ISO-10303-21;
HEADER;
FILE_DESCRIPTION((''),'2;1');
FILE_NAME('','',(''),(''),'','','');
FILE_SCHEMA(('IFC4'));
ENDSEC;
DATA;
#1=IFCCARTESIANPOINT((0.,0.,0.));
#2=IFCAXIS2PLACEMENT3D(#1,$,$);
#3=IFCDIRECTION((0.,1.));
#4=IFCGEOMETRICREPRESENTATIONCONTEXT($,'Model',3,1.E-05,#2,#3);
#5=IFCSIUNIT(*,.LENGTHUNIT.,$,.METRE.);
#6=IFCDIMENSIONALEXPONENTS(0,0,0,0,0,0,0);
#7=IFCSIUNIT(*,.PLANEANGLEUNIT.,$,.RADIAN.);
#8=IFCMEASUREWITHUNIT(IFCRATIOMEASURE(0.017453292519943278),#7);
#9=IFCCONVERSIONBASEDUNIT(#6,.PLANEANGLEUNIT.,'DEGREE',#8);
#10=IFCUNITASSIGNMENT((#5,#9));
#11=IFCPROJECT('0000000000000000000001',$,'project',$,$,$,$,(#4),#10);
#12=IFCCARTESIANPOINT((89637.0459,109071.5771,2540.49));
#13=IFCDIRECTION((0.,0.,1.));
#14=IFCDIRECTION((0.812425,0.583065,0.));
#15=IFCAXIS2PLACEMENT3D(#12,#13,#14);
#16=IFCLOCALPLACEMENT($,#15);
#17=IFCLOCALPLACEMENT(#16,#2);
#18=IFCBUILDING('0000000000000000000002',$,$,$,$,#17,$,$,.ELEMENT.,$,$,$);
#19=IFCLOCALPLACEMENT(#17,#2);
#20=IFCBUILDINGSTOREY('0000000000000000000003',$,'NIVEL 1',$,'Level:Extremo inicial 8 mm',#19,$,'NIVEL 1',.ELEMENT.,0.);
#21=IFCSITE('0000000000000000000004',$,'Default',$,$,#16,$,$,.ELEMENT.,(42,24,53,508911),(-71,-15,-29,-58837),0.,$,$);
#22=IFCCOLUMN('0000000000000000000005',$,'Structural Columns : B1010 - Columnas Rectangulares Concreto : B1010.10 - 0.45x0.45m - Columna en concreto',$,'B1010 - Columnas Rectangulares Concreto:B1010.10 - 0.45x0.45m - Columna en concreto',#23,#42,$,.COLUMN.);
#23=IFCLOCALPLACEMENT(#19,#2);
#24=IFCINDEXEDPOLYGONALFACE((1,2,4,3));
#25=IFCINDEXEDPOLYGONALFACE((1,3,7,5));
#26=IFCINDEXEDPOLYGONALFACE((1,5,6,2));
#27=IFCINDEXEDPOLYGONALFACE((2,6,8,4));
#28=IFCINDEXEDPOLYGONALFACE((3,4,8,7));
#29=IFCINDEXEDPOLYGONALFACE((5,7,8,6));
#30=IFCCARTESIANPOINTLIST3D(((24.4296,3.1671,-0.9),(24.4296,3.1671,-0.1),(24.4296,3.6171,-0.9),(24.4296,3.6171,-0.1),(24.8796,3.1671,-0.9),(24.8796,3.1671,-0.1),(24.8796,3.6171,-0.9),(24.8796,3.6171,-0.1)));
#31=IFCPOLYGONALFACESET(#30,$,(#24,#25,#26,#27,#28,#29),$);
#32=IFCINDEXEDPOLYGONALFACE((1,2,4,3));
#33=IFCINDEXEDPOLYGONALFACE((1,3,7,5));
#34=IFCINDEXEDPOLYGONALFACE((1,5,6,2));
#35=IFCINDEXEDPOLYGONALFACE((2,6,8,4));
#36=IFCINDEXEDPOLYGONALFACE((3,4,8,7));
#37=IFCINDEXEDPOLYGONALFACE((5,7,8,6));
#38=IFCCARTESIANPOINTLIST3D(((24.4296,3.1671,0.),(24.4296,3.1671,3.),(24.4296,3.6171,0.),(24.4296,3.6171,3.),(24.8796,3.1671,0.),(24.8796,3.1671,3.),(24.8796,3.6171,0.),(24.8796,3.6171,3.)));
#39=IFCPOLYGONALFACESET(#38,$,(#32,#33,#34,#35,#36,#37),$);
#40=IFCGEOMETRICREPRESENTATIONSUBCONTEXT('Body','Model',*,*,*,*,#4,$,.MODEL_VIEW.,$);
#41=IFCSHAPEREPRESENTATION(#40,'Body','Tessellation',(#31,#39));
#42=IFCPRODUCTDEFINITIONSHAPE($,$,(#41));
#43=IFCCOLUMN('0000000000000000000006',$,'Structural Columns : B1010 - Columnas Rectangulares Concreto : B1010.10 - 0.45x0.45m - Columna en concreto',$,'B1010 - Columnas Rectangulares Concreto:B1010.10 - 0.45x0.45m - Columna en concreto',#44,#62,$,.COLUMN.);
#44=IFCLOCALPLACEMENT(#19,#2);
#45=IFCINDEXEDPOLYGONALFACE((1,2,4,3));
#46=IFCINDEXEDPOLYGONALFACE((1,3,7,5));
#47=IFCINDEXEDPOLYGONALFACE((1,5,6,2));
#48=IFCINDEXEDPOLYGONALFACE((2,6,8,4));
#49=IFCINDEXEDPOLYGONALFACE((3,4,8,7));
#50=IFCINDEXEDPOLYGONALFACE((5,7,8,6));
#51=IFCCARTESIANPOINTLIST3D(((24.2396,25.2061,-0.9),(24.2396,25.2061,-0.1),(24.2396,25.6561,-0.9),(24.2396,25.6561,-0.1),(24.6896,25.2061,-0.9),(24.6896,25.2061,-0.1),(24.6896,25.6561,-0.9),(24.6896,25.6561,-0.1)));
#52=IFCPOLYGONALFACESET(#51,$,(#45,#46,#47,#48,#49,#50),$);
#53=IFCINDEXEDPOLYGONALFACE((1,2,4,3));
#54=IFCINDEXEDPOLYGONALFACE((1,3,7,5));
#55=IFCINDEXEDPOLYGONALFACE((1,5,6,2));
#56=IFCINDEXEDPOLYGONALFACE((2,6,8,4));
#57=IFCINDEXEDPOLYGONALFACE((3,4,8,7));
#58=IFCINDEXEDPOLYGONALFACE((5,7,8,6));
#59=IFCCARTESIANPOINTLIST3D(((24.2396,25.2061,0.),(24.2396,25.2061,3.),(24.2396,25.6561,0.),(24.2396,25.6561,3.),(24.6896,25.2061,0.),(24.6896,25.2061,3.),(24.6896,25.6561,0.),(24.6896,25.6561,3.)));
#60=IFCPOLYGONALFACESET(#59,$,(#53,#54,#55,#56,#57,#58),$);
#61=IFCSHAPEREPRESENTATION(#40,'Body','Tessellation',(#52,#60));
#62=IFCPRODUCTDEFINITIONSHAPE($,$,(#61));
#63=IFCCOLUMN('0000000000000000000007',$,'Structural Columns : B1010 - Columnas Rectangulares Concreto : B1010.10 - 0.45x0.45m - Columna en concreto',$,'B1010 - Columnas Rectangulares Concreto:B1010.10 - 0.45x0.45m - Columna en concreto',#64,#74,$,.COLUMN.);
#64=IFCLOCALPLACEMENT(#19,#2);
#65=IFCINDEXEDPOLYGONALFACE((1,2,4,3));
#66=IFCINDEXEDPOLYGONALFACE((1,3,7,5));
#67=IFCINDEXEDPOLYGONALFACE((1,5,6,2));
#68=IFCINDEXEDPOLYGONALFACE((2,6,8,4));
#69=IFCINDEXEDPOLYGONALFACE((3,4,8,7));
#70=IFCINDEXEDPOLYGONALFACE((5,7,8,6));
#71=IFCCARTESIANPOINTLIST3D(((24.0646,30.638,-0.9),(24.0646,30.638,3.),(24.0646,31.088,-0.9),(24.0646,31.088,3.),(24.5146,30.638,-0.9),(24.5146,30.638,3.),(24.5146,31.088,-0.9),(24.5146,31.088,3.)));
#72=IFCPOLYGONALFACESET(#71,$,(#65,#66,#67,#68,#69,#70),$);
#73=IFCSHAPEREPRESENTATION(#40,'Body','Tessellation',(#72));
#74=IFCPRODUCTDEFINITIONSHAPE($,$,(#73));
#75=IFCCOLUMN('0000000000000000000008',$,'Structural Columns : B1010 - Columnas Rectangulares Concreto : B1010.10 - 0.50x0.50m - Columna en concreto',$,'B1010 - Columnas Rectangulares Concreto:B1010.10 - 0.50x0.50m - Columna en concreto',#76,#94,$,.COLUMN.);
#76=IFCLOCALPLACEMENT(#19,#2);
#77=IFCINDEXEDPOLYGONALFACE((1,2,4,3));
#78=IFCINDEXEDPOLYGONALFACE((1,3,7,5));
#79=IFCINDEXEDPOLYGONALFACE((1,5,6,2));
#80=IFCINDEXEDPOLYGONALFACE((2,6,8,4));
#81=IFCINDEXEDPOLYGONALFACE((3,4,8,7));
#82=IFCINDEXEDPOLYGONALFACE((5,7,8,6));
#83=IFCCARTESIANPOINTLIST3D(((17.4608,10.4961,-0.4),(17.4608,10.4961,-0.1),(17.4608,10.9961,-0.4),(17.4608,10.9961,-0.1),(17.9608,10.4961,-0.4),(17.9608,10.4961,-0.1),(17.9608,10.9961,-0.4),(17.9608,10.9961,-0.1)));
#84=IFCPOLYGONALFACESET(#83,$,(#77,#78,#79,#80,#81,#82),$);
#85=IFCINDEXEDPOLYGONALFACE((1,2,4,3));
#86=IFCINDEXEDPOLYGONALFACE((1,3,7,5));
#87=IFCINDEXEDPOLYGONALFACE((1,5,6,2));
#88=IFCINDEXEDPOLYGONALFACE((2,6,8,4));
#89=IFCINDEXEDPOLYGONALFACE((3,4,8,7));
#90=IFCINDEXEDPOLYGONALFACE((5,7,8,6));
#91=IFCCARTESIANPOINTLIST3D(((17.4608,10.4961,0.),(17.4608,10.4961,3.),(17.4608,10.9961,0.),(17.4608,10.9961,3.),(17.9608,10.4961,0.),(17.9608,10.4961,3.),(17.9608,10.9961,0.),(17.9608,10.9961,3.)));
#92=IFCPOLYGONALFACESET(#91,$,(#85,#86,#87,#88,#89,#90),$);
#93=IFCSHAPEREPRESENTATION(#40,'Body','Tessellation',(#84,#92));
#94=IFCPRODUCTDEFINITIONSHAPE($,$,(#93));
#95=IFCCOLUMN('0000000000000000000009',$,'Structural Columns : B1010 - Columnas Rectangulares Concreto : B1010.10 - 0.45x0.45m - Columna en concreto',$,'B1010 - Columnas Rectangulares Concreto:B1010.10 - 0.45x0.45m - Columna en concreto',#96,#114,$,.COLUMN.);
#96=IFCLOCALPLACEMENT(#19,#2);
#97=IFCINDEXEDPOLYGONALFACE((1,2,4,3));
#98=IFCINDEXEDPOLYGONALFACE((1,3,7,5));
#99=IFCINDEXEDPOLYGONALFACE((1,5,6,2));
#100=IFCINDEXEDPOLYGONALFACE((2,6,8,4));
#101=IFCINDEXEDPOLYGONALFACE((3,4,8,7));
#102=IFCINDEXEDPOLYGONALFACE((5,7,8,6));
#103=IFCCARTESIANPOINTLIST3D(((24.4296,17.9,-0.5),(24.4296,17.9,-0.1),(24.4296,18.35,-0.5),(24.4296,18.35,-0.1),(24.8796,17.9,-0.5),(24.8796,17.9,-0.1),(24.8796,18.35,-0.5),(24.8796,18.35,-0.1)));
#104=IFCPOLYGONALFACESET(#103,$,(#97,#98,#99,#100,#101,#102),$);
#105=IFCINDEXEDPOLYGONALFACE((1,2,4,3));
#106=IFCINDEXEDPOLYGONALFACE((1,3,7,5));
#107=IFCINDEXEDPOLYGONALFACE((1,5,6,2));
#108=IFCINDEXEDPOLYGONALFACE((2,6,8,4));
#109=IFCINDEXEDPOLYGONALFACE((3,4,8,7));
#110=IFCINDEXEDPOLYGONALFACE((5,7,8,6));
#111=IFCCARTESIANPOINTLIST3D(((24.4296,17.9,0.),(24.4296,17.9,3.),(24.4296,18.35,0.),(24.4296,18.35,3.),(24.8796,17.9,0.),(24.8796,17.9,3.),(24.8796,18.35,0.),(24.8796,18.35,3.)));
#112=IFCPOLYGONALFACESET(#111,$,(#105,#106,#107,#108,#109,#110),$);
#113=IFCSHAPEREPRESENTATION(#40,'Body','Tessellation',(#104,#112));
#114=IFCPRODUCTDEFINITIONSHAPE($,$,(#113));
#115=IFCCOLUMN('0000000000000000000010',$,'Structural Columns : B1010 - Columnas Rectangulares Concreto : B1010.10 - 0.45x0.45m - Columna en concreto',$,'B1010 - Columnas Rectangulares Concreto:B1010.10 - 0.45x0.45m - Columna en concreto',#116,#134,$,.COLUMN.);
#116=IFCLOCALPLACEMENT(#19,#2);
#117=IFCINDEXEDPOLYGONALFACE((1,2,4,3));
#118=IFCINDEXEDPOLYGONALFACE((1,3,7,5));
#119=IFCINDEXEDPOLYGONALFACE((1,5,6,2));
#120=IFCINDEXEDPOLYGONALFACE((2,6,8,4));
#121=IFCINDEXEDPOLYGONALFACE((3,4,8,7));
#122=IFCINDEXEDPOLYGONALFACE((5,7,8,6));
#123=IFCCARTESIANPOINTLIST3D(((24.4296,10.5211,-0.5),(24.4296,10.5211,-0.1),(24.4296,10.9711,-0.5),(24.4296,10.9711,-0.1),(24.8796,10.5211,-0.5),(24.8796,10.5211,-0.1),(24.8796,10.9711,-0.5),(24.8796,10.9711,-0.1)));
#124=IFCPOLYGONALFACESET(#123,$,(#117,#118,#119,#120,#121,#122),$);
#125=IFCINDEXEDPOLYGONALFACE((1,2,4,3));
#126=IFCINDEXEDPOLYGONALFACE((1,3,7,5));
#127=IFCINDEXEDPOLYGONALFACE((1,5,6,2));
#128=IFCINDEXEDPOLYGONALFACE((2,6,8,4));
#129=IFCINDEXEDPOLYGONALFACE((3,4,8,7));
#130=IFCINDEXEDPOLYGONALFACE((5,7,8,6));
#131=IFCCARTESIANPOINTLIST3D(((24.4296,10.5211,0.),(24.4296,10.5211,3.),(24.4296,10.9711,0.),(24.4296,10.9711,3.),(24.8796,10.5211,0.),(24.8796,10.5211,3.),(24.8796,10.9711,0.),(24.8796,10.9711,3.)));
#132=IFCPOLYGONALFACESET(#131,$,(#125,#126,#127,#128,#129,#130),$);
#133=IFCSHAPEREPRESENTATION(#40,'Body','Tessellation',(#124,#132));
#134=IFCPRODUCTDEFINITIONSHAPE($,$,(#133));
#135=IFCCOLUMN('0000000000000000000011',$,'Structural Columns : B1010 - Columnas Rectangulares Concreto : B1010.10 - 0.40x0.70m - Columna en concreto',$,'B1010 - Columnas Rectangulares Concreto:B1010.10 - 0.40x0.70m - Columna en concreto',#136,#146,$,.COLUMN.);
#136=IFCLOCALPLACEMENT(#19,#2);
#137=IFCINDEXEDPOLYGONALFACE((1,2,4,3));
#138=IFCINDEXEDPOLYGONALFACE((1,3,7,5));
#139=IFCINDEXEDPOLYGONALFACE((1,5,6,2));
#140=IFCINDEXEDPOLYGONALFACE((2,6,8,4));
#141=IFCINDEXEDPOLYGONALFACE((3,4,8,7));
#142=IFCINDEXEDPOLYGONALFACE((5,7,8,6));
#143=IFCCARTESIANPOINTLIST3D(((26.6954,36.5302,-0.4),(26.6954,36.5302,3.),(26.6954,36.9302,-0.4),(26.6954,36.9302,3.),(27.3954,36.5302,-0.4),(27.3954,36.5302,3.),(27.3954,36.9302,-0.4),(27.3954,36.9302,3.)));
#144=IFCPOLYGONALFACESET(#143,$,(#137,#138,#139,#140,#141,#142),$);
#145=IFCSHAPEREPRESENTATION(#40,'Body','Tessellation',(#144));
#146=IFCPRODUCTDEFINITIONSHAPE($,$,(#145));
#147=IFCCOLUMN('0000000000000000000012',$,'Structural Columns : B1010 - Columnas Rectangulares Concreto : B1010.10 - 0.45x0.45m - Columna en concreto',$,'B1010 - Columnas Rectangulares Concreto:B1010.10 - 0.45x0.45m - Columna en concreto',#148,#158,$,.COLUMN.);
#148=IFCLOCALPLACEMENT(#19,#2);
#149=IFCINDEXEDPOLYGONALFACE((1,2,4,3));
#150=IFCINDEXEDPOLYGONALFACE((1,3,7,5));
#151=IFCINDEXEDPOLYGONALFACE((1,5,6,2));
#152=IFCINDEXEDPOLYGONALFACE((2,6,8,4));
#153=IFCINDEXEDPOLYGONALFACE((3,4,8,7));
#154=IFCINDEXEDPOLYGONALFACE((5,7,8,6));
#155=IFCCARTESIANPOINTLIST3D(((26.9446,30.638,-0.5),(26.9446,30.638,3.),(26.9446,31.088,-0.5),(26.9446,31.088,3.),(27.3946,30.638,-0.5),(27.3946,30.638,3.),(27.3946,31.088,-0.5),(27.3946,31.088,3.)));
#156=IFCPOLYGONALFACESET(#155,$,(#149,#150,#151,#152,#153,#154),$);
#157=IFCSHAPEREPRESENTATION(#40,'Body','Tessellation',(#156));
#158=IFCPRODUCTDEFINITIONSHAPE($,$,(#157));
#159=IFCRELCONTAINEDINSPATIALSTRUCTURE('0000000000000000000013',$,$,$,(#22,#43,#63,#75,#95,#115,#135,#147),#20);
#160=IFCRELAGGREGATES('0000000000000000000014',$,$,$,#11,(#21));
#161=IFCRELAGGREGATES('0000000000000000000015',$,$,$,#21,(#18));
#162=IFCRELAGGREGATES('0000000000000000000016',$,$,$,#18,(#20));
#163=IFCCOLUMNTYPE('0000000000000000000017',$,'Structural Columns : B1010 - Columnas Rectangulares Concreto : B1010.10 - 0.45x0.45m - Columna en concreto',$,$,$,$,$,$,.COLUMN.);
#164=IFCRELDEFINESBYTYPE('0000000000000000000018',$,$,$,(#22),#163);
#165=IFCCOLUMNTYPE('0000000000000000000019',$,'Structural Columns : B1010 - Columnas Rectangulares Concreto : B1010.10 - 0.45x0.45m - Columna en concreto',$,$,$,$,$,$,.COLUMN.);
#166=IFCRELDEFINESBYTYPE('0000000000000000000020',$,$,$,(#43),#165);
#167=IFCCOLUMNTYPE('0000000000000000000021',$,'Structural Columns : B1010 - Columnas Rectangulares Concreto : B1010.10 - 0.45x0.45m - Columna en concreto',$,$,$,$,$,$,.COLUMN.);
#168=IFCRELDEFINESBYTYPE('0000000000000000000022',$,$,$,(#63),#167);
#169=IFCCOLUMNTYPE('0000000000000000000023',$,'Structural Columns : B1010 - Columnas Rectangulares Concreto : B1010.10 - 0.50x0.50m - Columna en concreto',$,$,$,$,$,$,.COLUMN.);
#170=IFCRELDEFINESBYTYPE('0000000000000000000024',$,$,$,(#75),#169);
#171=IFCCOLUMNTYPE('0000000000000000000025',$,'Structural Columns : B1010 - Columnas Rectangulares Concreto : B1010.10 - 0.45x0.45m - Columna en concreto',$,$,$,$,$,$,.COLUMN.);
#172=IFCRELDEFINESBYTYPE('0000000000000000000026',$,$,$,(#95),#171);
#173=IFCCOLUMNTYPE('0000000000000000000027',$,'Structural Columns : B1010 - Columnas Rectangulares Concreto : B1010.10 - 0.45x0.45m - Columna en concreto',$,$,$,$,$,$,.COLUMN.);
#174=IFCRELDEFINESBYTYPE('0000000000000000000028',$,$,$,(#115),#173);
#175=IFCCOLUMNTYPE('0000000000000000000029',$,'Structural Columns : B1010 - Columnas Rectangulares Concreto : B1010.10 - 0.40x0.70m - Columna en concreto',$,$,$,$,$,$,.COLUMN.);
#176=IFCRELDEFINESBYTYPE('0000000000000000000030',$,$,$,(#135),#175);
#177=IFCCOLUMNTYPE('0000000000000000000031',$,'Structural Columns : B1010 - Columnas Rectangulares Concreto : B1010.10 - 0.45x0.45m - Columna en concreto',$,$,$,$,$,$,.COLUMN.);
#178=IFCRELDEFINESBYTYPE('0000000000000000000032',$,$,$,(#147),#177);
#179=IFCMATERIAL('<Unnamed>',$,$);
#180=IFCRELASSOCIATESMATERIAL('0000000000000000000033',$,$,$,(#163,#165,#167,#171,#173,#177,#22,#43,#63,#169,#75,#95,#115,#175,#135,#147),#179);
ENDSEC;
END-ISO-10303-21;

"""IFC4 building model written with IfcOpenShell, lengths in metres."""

from ifc_helpers import new_model, entity, si_unit, converted_unit, direction, frame, frame_2d, origin, origin_2d_with_axis, place, context, subcontext, project, spatial, polyline, segment, composite_curve, rectangle, outline, extrude, source, transform, mapped, material, material_profile, profile_set, profile_usage, type_object, type_shapes, element, save


model = new_model("IFC4")

# Units and contexts
model_context = context("Model", 3, precision=1e-05, world=origin(), true_north=direction((0.0, 1.0)))
body_context = subcontext(model_context, "Body", "Model", "MODEL_VIEW")
ifc_project = project(units=[si_unit("LENGTHUNIT", "METRE"), converted_unit("PLANEANGLEUNIT", "DEGREE", entity("IfcRatioMeasure", 0.017453292519943278), si_unit("PLANEANGLEUNIT", "RADIAN"), dimensions=[0, 0, 0, 0, 0, 0, 0])], contexts=[model_context])

# Site, building, storey
site_placement = place(None, frame((89637.0459, 109071.5771, 2540.49), z_axis=(0.0, 0.0, 1.0), x_axis=(0.812425, 0.583065, 0.0)))
site = spatial("IfcSite", under=ifc_project, at=site_placement, Name="Default", CompositionType="ELEMENT", RefLatitude=(42, 24, 53, 508911), RefLongitude=(-71, -15, -29, -58837), RefElevation=0.0)
building_placement = place(site_placement, origin())
building = spatial("IfcBuilding", under=site, at=building_placement, CompositionType="ELEMENT")
storey_placement = place(building_placement, origin())
storey = spatial("IfcBuildingStorey", under=building, at=storey_placement, Name="NIVEL 1", ObjectType="Level:Extremo inicial 8 mm", LongName="NIVEL 1", CompositionType="ELEMENT", Elevation=0.0)

# Columns
ifc_material = material(Name="<Unnamed>")
ifc_material_profile_1 = material_profile(ifc_material, outline(composite_curve([segment(polyline([(0.35, 0.2, 0.0), (0.35, -0.2, 0.0)]), True, "CONTINUOUS"), segment(polyline([(0.35, -0.2, 0.0), (-0.35, -0.2, 0.0)]), True, "CONTINUOUS"), segment(polyline([(-0.35, -0.2, 0.0), (-0.35, 0.2, 0.0)]), True, "CONTINUOUS"), segment(polyline([(-0.35, 0.2, 0.0), (0.35, 0.2, 0.0)]), True, "CONTINUOUS")], self_intersect=False), kind="CURVE"), Name="B1010.10 - 0.40x0.70m - Columna en concreto")
ifc_material_profile_2 = material_profile(ifc_material, outline(composite_curve([segment(polyline([(0.35, 0.2, 3.0), (-0.35, 0.2, 3.0)]), True, "CONTINUOUS"), segment(polyline([(-0.35, 0.2, 3.0), (-0.35, -0.2, 3.0)]), True, "CONTINUOUS"), segment(polyline([(-0.35, -0.2, 3.0), (0.35, -0.2, 3.0)]), True, "CONTINUOUS"), segment(polyline([(0.35, -0.2, 3.0), (0.35, 0.2, 3.0)]), True, "CONTINUOUS")], self_intersect=False), kind="CURVE"), Name="B1010.10 - 0.40x0.70m - Columna en concreto")
ifc_profile_set_1 = profile_set([ifc_material_profile_1, ifc_material_profile_2], Name="B1010.10 - 0.40x0.70m - Columna en concreto")
ifc_material_profile_3 = material_profile(ifc_material, outline(composite_curve([segment(polyline([(0.225, 0.225, 0.0), (0.225, -0.225, 0.0)]), True, "CONTINUOUS"), segment(polyline([(0.225, -0.225, 0.0), (-0.225, -0.225, 0.0)]), True, "CONTINUOUS"), segment(polyline([(-0.225, -0.225, 0.0), (-0.225, 0.225, 0.0)]), True, "CONTINUOUS"), segment(polyline([(-0.225, 0.225, 0.0), (0.225, 0.225, 0.0)]), True, "CONTINUOUS")], self_intersect=False), kind="CURVE"), Name="B1010.10 - 0.45x0.45m - Columna en concreto")
ifc_material_profile_4 = material_profile(ifc_material, outline(composite_curve([segment(polyline([(0.225, 0.225, 3.0), (-0.225, 0.225, 3.0)]), True, "CONTINUOUS"), segment(polyline([(-0.225, 0.225, 3.0), (-0.225, -0.225, 3.0)]), True, "CONTINUOUS"), segment(polyline([(-0.225, -0.225, 3.0), (0.225, -0.225, 3.0)]), True, "CONTINUOUS"), segment(polyline([(0.225, -0.225, 3.0), (0.225, 0.225, 3.0)]), True, "CONTINUOUS")], self_intersect=False), kind="CURVE"), Name="B1010.10 - 0.45x0.45m - Columna en concreto")
ifc_profile_set_2 = profile_set([ifc_material_profile_3, ifc_material_profile_4], Name="B1010.10 - 0.45x0.45m - Columna en concreto")
ifc_material_profile_5 = material_profile(ifc_material, outline(composite_curve([segment(polyline([(0.25, 0.25, 0.0), (0.25, -0.25, 0.0)]), True, "CONTINUOUS"), segment(polyline([(0.25, -0.25, 0.0), (-0.25, -0.25, 0.0)]), True, "CONTINUOUS"), segment(polyline([(-0.25, -0.25, 0.0), (-0.25, 0.25, 0.0)]), True, "CONTINUOUS"), segment(polyline([(-0.25, 0.25, 0.0), (0.25, 0.25, 0.0)]), True, "CONTINUOUS")], self_intersect=False), kind="CURVE"), Name="B1010.10 - 0.50x0.50m - Columna en concreto")
ifc_material_profile_6 = material_profile(ifc_material, outline(composite_curve([segment(polyline([(0.25, 0.25, 3.0), (-0.25, 0.25, 3.0)]), True, "CONTINUOUS"), segment(polyline([(-0.25, 0.25, 3.0), (-0.25, -0.25, 3.0)]), True, "CONTINUOUS"), segment(polyline([(-0.25, -0.25, 3.0), (0.25, -0.25, 3.0)]), True, "CONTINUOUS"), segment(polyline([(0.25, -0.25, 3.0), (0.25, 0.25, 3.0)]), True, "CONTINUOUS")], self_intersect=False), kind="CURVE"), Name="B1010.10 - 0.50x0.50m - Columna en concreto")
ifc_profile_set_3 = profile_set([ifc_material_profile_5, ifc_material_profile_6], Name="B1010.10 - 0.50x0.50m - Columna en concreto")
ifc_profile_usage_1 = profile_usage(ifc_profile_set_2)
column_type_1 = type_object("IfcColumnType", Name="Structural Columns : B1010 - Columnas Rectangulares Concreto : B1010.10 - 0.45x0.45m - Columna en concreto", PredefinedType="COLUMN", material=ifc_profile_set_2)
shared_shape_1 = source(origin(), body_context, "Body", "SweptSolid", [
    extrude(rectangle(XDim=0.45, YDim=0.45, at=frame_2d((0.0, 0.0), x_axis=(1.0, 0.0))), frame((24.6546, 3.3921, -0.9), z_axis=(0.0, 0.0, 1.0), x_axis=(0.0, -1.0, 0.0)), (0.0, 0.0, 1.0), 0.8),
    extrude(rectangle(XDim=0.45, YDim=0.45, at=frame_2d((0.0, 0.0), x_axis=(1.0, 0.0))), frame((24.6546, 3.3921, 0.0), z_axis=(0.0, 0.0, 1.0), x_axis=(0.0, -1.0, 0.0)), (0.0, 0.0, 1.0), 3.0),
])
type_shapes(column_type_1, [shared_shape_1])
column_1_placement = place(storey_placement, origin())
element("IfcColumn", 1, at=column_1_placement, inside=storey, type_object=column_type_1, material=ifc_profile_usage_1, Name="Structural Columns : B1010 - Columnas Rectangulares Concreto : B1010.10 - 0.45x0.45m - Columna en concreto", ObjectType="B1010 - Columnas Rectangulares Concreto:B1010.10 - 0.45x0.45m - Columna en concreto", PredefinedType="COLUMN", context=body_context, shape_type="MappedRepresentation", body=[
    mapped(shared_shape_1, transform((0.0, 0.0, 0.0), scale=1.0)),
])
ifc_profile_usage_2 = profile_usage(ifc_profile_set_2)
column_type_2 = type_object("IfcColumnType", Name="Structural Columns : B1010 - Columnas Rectangulares Concreto : B1010.10 - 0.45x0.45m - Columna en concreto", PredefinedType="COLUMN", material=ifc_profile_set_2)
shared_shape_2 = source(origin(), body_context, "Body", "SweptSolid", [
    extrude(rectangle(XDim=0.45, YDim=0.45, at=origin_2d_with_axis()), frame((24.4646, 25.4311, -0.9), z_axis=(0.0, 0.0, 1.0), x_axis=(0.0, -1.0, 0.0)), (0.0, 0.0, 1.0), 0.8),
    extrude(rectangle(XDim=0.45, YDim=0.45, at=origin_2d_with_axis()), frame((24.4646, 25.4311, 0.0), z_axis=(0.0, 0.0, 1.0), x_axis=(0.0, -1.0, 0.0)), (0.0, 0.0, 1.0), 3.0),
])
type_shapes(column_type_2, [shared_shape_2])
column_2_placement = place(storey_placement, origin())
element("IfcColumn", 2, at=column_2_placement, inside=storey, type_object=column_type_2, material=ifc_profile_usage_2, Name="Structural Columns : B1010 - Columnas Rectangulares Concreto : B1010.10 - 0.45x0.45m - Columna en concreto", ObjectType="B1010 - Columnas Rectangulares Concreto:B1010.10 - 0.45x0.45m - Columna en concreto", PredefinedType="COLUMN", context=body_context, shape_type="MappedRepresentation", body=[
    mapped(shared_shape_2, transform((0.0, 0.0, 0.0), scale=1.0)),
])
ifc_profile_usage_3 = profile_usage(ifc_profile_set_2)
column_type_3 = type_object("IfcColumnType", Name="Structural Columns : B1010 - Columnas Rectangulares Concreto : B1010.10 - 0.45x0.45m - Columna en concreto", PredefinedType="COLUMN", material=ifc_profile_set_2)
shared_shape_3 = source(origin(), body_context, "Body", "SweptSolid", [
    extrude(rectangle(XDim=0.45, YDim=0.45, at=origin_2d_with_axis()), frame((24.2896, 30.863, -0.9), z_axis=(0.0, 0.0, 1.0), x_axis=(0.0, -1.0, 0.0)), (0.0, 0.0, 1.0), 3.9),
])
type_shapes(column_type_3, [shared_shape_3])
column_3_placement = place(storey_placement, origin())
element("IfcColumn", 3, at=column_3_placement, inside=storey, type_object=column_type_3, material=ifc_profile_usage_3, Name="Structural Columns : B1010 - Columnas Rectangulares Concreto : B1010.10 - 0.45x0.45m - Columna en concreto", ObjectType="B1010 - Columnas Rectangulares Concreto:B1010.10 - 0.45x0.45m - Columna en concreto", PredefinedType="COLUMN", context=body_context, shape_type="MappedRepresentation", body=[
    mapped(shared_shape_3, transform((0.0, 0.0, 0.0), scale=1.0)),
])
ifc_profile_usage_4 = profile_usage(ifc_profile_set_3)
column_type_4 = type_object("IfcColumnType", Name="Structural Columns : B1010 - Columnas Rectangulares Concreto : B1010.10 - 0.50x0.50m - Columna en concreto", PredefinedType="COLUMN", material=ifc_profile_set_3)
shared_shape_4 = source(origin(), body_context, "Body", "SweptSolid", [
    extrude(rectangle(XDim=0.5, YDim=0.5, at=origin_2d_with_axis()), frame((17.7108, 10.7461, -0.4), z_axis=(0.0, 0.0, 1.0), x_axis=(0.0, -1.0, 0.0)), (0.0, 0.0, 1.0), 0.3),
    extrude(rectangle(XDim=0.5, YDim=0.5, at=origin_2d_with_axis()), frame((17.7108, 10.7461, 0.0), z_axis=(0.0, 0.0, 1.0), x_axis=(0.0, -1.0, 0.0)), (0.0, 0.0, 1.0), 3.0),
])
type_shapes(column_type_4, [shared_shape_4])
column_4_placement = place(storey_placement, origin())
element("IfcColumn", 4, at=column_4_placement, inside=storey, type_object=column_type_4, material=ifc_profile_usage_4, Name="Structural Columns : B1010 - Columnas Rectangulares Concreto : B1010.10 - 0.50x0.50m - Columna en concreto", ObjectType="B1010 - Columnas Rectangulares Concreto:B1010.10 - 0.50x0.50m - Columna en concreto", PredefinedType="COLUMN", context=body_context, shape_type="MappedRepresentation", body=[
    mapped(shared_shape_4, transform((0.0, 0.0, 0.0), scale=1.0)),
])
ifc_profile_usage_5 = profile_usage(ifc_profile_set_2)
column_type_5 = type_object("IfcColumnType", Name="Structural Columns : B1010 - Columnas Rectangulares Concreto : B1010.10 - 0.45x0.45m - Columna en concreto", PredefinedType="COLUMN", material=ifc_profile_set_2)
shared_shape_5 = source(origin(), body_context, "Body", "SweptSolid", [
    extrude(rectangle(XDim=0.45, YDim=0.45, at=origin_2d_with_axis()), frame((24.6546, 18.125, -0.5), z_axis=(0.0, 0.0, 1.0), x_axis=(0.0, -1.0, 0.0)), (0.0, 0.0, 1.0), 0.4),
    extrude(rectangle(XDim=0.45, YDim=0.45, at=origin_2d_with_axis()), frame((24.6546, 18.125, 0.0), z_axis=(0.0, 0.0, 1.0), x_axis=(0.0, -1.0, 0.0)), (0.0, 0.0, 1.0), 3.0),
])
type_shapes(column_type_5, [shared_shape_5])
column_5_placement = place(storey_placement, origin())
element("IfcColumn", 5, at=column_5_placement, inside=storey, type_object=column_type_5, material=ifc_profile_usage_5, Name="Structural Columns : B1010 - Columnas Rectangulares Concreto : B1010.10 - 0.45x0.45m - Columna en concreto", ObjectType="B1010 - Columnas Rectangulares Concreto:B1010.10 - 0.45x0.45m - Columna en concreto", PredefinedType="COLUMN", context=body_context, shape_type="MappedRepresentation", body=[
    mapped(shared_shape_5, transform((0.0, 0.0, 0.0), scale=1.0)),
])
ifc_profile_usage_6 = profile_usage(ifc_profile_set_2)
column_type_6 = type_object("IfcColumnType", Name="Structural Columns : B1010 - Columnas Rectangulares Concreto : B1010.10 - 0.45x0.45m - Columna en concreto", PredefinedType="COLUMN", material=ifc_profile_set_2)
shared_shape_6 = source(origin(), body_context, "Body", "SweptSolid", [
    extrude(rectangle(XDim=0.45, YDim=0.45, at=origin_2d_with_axis()), frame((24.6546, 10.7461, -0.5), z_axis=(0.0, 0.0, 1.0), x_axis=(0.0, -1.0, 0.0)), (0.0, 0.0, 1.0), 0.4),
    extrude(rectangle(XDim=0.45, YDim=0.45, at=origin_2d_with_axis()), frame((24.6546, 10.7461, 0.0), z_axis=(0.0, 0.0, 1.0), x_axis=(0.0, -1.0, 0.0)), (0.0, 0.0, 1.0), 3.0),
])
type_shapes(column_type_6, [shared_shape_6])
column_6_placement = place(storey_placement, origin())
element("IfcColumn", 6, at=column_6_placement, inside=storey, type_object=column_type_6, material=ifc_profile_usage_6, Name="Structural Columns : B1010 - Columnas Rectangulares Concreto : B1010.10 - 0.45x0.45m - Columna en concreto", ObjectType="B1010 - Columnas Rectangulares Concreto:B1010.10 - 0.45x0.45m - Columna en concreto", PredefinedType="COLUMN", context=body_context, shape_type="MappedRepresentation", body=[
    mapped(shared_shape_6, transform((0.0, 0.0, 0.0), scale=1.0)),
])
ifc_profile_usage_7 = profile_usage(ifc_profile_set_1)
column_type_7 = type_object("IfcColumnType", Name="Structural Columns : B1010 - Columnas Rectangulares Concreto : B1010.10 - 0.40x0.70m - Columna en concreto", PredefinedType="COLUMN", material=ifc_profile_set_1)
shared_shape_7 = source(origin(), body_context, "Body", "SweptSolid", [
    extrude(rectangle(XDim=0.4, YDim=0.7, at=origin_2d_with_axis()), frame((27.0454, 36.7302, -0.4), z_axis=(0.0, 0.0, 1.0), x_axis=(0.0, -1.0, 0.0)), (0.0, 0.0, 1.0), 3.4),
])
type_shapes(column_type_7, [shared_shape_7])
column_7_placement = place(storey_placement, origin())
element("IfcColumn", 7, at=column_7_placement, inside=storey, type_object=column_type_7, material=ifc_profile_usage_7, Name="Structural Columns : B1010 - Columnas Rectangulares Concreto : B1010.10 - 0.40x0.70m - Columna en concreto", ObjectType="B1010 - Columnas Rectangulares Concreto:B1010.10 - 0.40x0.70m - Columna en concreto", PredefinedType="COLUMN", context=body_context, shape_type="MappedRepresentation", body=[
    mapped(shared_shape_7, transform((0.0, 0.0, 0.0), scale=1.0)),
])
ifc_profile_usage_8 = profile_usage(ifc_profile_set_2)
column_type_8 = type_object("IfcColumnType", Name="Structural Columns : B1010 - Columnas Rectangulares Concreto : B1010.10 - 0.45x0.45m - Columna en concreto", PredefinedType="COLUMN", material=ifc_profile_set_2)
shared_shape_8 = source(origin(), body_context, "Body", "SweptSolid", [
    extrude(rectangle(XDim=0.45, YDim=0.45, at=origin_2d_with_axis()), frame((27.1696, 30.863, -0.5), z_axis=(0.0, 0.0, 1.0), x_axis=(0.0, -1.0, 0.0)), (0.0, 0.0, 1.0), 3.5),
])
type_shapes(column_type_8, [shared_shape_8])
column_8_placement = place(storey_placement, origin())
element("IfcColumn", 8, at=column_8_placement, inside=storey, type_object=column_type_8, material=ifc_profile_usage_8, Name="Structural Columns : B1010 - Columnas Rectangulares Concreto : B1010.10 - 0.45x0.45m - Columna en concreto", ObjectType="B1010 - Columnas Rectangulares Concreto:B1010.10 - 0.45x0.45m - Columna en concreto", PredefinedType="COLUMN", context=body_context, shape_type="MappedRepresentation", body=[
    mapped(shared_shape_8, transform((0.0, 0.0, 0.0), scale=1.0)),
])

save(model, "model.ifc")
